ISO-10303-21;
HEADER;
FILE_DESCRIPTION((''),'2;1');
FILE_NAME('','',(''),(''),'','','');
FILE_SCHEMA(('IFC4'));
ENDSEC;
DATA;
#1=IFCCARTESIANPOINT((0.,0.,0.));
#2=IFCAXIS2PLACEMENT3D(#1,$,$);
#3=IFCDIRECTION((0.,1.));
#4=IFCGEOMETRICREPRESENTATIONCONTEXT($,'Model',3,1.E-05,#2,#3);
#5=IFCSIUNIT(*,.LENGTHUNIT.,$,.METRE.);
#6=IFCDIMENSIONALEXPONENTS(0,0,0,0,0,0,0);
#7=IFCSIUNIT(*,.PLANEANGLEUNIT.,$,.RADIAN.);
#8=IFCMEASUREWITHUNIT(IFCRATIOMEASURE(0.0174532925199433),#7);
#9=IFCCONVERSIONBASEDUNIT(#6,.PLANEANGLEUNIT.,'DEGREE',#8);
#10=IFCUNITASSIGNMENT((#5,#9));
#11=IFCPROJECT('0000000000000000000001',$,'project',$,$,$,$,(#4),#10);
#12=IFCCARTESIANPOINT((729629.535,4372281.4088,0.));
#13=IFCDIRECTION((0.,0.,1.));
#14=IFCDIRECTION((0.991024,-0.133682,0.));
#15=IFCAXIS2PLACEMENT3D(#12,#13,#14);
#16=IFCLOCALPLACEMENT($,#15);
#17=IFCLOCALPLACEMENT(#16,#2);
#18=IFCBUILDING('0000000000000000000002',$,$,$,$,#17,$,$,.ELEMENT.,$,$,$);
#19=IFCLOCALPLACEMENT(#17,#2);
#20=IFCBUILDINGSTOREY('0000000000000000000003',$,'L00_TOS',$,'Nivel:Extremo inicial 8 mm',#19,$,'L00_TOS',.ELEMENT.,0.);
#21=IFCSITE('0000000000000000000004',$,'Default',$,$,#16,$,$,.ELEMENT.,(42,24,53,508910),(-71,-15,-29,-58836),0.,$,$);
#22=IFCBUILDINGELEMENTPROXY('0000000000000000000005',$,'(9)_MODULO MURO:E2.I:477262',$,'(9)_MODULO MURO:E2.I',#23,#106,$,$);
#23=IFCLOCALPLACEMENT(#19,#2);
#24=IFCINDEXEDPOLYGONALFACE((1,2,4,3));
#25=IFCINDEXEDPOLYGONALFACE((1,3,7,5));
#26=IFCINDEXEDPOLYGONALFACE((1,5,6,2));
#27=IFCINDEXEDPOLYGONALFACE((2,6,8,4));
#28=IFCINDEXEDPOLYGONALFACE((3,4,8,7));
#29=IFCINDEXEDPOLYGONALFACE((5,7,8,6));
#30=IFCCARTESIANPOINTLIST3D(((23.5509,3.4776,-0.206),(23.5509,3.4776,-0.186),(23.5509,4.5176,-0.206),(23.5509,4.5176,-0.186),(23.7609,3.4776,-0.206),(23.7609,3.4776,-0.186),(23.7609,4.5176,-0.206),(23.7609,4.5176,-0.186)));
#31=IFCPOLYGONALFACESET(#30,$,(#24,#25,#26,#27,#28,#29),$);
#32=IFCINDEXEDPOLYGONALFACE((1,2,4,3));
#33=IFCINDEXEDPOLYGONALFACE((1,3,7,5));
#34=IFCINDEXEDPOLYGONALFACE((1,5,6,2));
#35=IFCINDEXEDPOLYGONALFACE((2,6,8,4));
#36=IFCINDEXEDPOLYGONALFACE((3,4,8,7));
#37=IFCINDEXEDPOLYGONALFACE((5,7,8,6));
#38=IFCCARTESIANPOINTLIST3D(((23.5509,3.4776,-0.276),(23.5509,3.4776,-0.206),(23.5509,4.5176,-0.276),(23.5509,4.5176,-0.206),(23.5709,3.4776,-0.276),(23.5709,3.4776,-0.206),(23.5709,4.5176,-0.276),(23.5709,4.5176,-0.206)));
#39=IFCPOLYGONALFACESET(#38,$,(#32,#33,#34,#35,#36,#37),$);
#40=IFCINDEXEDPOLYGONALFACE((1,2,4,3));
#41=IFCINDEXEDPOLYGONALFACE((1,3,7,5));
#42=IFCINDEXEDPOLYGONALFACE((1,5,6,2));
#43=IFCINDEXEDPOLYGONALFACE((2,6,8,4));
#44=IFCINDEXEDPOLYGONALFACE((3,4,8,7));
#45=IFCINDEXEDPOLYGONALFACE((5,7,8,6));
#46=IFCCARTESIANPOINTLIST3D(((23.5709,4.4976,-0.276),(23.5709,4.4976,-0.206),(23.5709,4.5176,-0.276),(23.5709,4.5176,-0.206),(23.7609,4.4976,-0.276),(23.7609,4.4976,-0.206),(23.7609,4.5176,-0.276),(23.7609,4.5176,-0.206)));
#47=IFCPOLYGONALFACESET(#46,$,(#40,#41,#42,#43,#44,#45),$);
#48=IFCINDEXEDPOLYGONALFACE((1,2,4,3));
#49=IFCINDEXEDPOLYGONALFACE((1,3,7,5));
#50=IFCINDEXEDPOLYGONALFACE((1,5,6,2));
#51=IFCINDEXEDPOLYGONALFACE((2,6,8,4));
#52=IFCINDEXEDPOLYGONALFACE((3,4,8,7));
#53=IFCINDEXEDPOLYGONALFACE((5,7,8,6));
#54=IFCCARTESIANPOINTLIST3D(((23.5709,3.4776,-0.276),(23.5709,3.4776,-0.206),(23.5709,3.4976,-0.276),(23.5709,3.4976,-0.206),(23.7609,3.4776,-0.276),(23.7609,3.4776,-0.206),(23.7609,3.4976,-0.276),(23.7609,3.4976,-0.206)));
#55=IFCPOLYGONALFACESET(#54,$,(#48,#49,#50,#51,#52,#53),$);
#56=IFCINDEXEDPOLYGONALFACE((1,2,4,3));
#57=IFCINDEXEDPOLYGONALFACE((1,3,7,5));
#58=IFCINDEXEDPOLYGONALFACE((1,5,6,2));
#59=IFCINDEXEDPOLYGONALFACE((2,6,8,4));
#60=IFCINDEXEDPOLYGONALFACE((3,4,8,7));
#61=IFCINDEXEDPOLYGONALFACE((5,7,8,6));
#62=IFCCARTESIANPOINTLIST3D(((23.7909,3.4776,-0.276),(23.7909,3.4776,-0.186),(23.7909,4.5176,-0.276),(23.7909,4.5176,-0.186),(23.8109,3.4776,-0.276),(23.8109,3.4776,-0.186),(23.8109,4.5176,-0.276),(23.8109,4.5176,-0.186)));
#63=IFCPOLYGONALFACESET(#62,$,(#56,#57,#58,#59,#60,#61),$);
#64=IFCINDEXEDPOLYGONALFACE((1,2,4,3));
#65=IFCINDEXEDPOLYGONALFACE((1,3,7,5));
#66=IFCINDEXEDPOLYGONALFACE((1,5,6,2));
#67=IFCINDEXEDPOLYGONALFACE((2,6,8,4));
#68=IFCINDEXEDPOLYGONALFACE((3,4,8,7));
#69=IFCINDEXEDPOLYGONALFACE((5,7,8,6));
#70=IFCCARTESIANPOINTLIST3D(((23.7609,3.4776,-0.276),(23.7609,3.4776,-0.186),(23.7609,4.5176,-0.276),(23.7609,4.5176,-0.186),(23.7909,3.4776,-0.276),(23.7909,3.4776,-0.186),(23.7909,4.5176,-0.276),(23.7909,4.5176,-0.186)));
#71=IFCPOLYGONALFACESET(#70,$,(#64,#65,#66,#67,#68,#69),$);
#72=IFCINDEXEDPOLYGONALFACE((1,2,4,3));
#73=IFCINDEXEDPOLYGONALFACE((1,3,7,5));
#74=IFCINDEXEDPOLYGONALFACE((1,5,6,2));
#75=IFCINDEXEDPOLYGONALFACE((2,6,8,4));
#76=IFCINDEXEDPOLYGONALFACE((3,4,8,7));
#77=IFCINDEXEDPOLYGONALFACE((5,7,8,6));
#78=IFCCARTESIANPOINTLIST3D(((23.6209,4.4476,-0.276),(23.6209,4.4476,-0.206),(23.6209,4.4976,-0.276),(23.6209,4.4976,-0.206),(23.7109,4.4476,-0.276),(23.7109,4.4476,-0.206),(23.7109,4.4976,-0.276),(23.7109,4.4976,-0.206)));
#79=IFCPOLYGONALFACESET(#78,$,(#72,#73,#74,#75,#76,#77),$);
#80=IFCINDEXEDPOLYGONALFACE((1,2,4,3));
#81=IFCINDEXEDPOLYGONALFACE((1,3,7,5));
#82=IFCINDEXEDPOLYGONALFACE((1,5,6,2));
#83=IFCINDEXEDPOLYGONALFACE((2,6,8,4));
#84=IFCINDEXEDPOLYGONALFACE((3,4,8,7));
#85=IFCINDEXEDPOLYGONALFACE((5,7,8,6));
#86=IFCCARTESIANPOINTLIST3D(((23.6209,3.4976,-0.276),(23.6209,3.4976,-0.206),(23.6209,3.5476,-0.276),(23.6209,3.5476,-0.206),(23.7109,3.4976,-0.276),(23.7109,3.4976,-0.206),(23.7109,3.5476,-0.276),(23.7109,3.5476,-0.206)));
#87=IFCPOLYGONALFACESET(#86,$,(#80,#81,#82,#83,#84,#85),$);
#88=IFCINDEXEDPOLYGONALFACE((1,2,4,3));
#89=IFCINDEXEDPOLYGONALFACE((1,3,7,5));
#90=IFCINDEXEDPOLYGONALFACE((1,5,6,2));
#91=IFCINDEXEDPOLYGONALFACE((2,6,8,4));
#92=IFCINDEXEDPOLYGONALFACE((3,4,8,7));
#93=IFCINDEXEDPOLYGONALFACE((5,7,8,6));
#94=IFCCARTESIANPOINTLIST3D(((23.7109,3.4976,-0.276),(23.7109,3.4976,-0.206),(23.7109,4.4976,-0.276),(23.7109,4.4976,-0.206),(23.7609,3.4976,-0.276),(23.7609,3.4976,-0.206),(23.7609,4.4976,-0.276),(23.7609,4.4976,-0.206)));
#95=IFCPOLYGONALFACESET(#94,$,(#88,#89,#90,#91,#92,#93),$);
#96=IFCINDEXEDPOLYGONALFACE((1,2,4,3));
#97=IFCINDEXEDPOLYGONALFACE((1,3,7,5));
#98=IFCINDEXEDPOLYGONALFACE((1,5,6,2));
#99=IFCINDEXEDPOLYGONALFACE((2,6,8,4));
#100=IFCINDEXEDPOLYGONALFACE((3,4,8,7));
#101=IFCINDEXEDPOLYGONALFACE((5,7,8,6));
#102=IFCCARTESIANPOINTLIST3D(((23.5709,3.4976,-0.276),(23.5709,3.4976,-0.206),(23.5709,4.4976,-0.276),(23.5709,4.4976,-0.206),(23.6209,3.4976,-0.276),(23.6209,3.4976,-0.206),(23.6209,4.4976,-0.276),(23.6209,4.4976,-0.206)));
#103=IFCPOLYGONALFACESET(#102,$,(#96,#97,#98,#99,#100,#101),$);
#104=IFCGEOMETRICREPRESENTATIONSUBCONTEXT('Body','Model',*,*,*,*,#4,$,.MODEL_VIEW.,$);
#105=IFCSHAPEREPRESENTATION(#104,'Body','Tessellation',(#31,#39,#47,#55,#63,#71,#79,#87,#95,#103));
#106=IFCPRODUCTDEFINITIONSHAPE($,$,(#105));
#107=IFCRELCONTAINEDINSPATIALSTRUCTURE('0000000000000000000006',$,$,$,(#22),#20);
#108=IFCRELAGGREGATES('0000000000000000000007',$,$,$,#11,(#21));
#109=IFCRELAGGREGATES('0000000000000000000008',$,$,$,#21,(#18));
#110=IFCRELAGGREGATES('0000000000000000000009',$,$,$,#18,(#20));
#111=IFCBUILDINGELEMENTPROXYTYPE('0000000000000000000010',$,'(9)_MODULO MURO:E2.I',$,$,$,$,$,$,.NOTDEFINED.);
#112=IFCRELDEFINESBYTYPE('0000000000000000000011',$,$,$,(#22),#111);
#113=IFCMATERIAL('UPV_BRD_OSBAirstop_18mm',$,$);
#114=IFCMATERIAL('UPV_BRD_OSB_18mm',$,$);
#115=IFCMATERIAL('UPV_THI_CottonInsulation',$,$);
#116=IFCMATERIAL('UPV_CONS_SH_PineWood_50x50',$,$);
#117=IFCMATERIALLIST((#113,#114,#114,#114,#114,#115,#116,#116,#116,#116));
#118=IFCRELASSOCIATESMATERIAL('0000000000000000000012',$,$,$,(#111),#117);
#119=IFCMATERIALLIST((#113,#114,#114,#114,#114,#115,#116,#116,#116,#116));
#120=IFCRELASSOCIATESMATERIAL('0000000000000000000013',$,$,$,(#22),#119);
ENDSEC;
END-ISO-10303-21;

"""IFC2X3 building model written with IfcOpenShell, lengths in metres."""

from ifc_helpers import new_model, entity, si_unit, converted_unit, direction, frame, frame_2d, origin, origin_2d_with_axis, place, context, subcontext, project, spatial, rectangle, extrude, source, transform, mapped, material, material_list, type_object, type_shapes, element, save


model = new_model("IFC2X3")

# Units and contexts
model_context = context("Model", 3, precision=1e-05, world=origin(), true_north=direction((0.0, 1.0)))
body_context = subcontext(model_context, "Body", "Model", "MODEL_VIEW")
ifc_project = project(units=[si_unit("LENGTHUNIT", "METRE"), converted_unit("PLANEANGLEUNIT", "DEGREE", entity("IfcRatioMeasure", 0.0174532925199433), si_unit("PLANEANGLEUNIT", "RADIAN"), dimensions=[0, 0, 0, 0, 0, 0, 0])], contexts=[model_context])

# Site, building, storey
site_placement = place(None, frame((729629.535, 4372281.4088, 0.0), z_axis=(0.0, 0.0, 1.0), x_axis=(0.991024, -0.133682, 0.0)))
site = spatial("IfcSite", under=ifc_project, at=site_placement, Name="Default", CompositionType="ELEMENT", RefLatitude=(42, 24, 53, 508910), RefLongitude=(-71, -15, -29, -58836), RefElevation=0.0)
building_placement = place(site_placement, origin())
building = spatial("IfcBuilding", under=site, at=building_placement, CompositionType="ELEMENT")
storey_placement = place(building_placement, origin())
storey = spatial("IfcBuildingStorey", under=building, at=storey_placement, Name="L00_TOS", ObjectType="Nivel:Extremo inicial 8 mm", LongName="L00_TOS", CompositionType="ELEMENT", Elevation=0.0)

# Building element proxy
ifc_material_1 = material(Name="UPV_BRD_OSBAirstop_18mm")
ifc_material_2 = material(Name="UPV_BRD_OSB_18mm")
ifc_material_3 = material(Name="UPV_THI_CottonInsulation")
ifc_material_4 = material(Name="UPV_CONS_SH_PineWood_50x50")
ifc_material_list_1 = material_list([ifc_material_1, ifc_material_2, ifc_material_2, ifc_material_2, ifc_material_2, ifc_material_3, ifc_material_4, ifc_material_4, ifc_material_4, ifc_material_4])
ifc_material_list_2 = material_list([ifc_material_1, ifc_material_2, ifc_material_2, ifc_material_2, ifc_material_2, ifc_material_3, ifc_material_4, ifc_material_4, ifc_material_4, ifc_material_4])
building_element_proxy_type_1 = type_object("IfcBuildingElementProxyType", Name="(9)_MODULO MURO:E2.I", PredefinedType="NOTDEFINED", material=ifc_material_list_2)
shared_shape_1 = source(origin(), body_context, "Body", "SweptSolid", [
    extrude(rectangle(XDim=1.04, YDim=0.21, at=origin_2d_with_axis()), frame((0.0, -0.01, 0.07)), (0.0, 0.0, 1.0), 0.02),
    extrude(rectangle(XDim=1.04, YDim=0.02, at=origin_2d_with_axis()), frame((0.0, -0.105, 0.0), z_axis=(0.0, 0.0, 1.0), x_axis=(-1.0, 0.0, 0.0)), (0.0, 0.0, 1.0), 0.07),
    extrude(rectangle(XDim=0.19, YDim=0.02, at=frame_2d((0.0, 0.0), x_axis=(1.0, 0.0))), frame((-0.51, 0.0, 0.0), z_axis=(0.0, 0.0, 1.0), x_axis=(0.0, -1.0, 0.0)), (0.0, 0.0, 1.0), 0.07),
    extrude(rectangle(XDim=0.19, YDim=0.02, at=origin_2d_with_axis()), frame((0.51, 0.0, 0.0), z_axis=(0.0, 0.0, 1.0), x_axis=(0.0, -1.0, 0.0)), (0.0, 0.0, 1.0), 0.07),
    extrude(rectangle(XDim=1.04, YDim=0.02, at=frame_2d((0.0, 0.0), x_axis=(1.0, 0.0))), frame((0.0, 0.135, 0.0), z_axis=(0.0, 0.0, 1.0), x_axis=(-1.0, 0.0, 0.0)), (0.0, 0.0, 1.0), 0.09),
    extrude(rectangle(XDim=1.04, YDim=0.03, at=origin_2d_with_axis()), frame((0.0, 0.11, 0.0)), (0.0, 0.0, 1.0), 0.09),
    extrude(rectangle(XDim=0.09, YDim=0.05, at=frame_2d((0.0, 0.0), x_axis=(1.0, 0.0))), frame((-0.475, 0.0, 0.0), z_axis=(0.0, 0.0, 1.0), x_axis=(0.0, -1.0, 0.0)), (0.0, 0.0, 1.0), 0.07),
    extrude(rectangle(XDim=0.09, YDim=0.05, at=frame_2d((0.0, 0.0), x_axis=(1.0, 0.0))), frame((0.475, 0.0, 0.0), z_axis=(0.0, 0.0, 1.0), x_axis=(0.0, -1.0, 0.0)), (0.0, 0.0, 1.0), 0.07),
    extrude(rectangle(XDim=0.05, YDim=1.0, at=origin_2d_with_axis()), frame((0.0, 0.07, 0.0), z_axis=(0.0, 0.0, 1.0), x_axis=(0.0, -1.0, 0.0)), (0.0, 0.0, 1.0), 0.07),
    extrude(rectangle(XDim=0.05, YDim=1.0, at=origin_2d_with_axis()), frame((0.0, -0.07, 0.0), z_axis=(0.0, 0.0, 1.0), x_axis=(0.0, -1.0, 0.0)), (0.0, 0.0, 1.0), 0.07),
])
type_shapes(building_element_proxy_type_1, [shared_shape_1])
proxy_1_placement = place(storey_placement, frame((23.6659, 3.9976, -0.276), z_axis=(0.0, 0.0, 1.0), x_axis=(0.0, -1.0, 0.0)))
element("IfcBuildingElementProxy", 1, at=proxy_1_placement, inside=storey, type_object=building_element_proxy_type_1, material=ifc_material_list_1, Name="(9)_MODULO MURO:E2.I:477262", ObjectType="(9)_MODULO MURO:E2.I", context=body_context, shape_type="MappedRepresentation", body=[
    mapped(shared_shape_1, transform((0.0, 0.0, 0.0), scale=1.0)),
])

save(model, "model.ifc")
